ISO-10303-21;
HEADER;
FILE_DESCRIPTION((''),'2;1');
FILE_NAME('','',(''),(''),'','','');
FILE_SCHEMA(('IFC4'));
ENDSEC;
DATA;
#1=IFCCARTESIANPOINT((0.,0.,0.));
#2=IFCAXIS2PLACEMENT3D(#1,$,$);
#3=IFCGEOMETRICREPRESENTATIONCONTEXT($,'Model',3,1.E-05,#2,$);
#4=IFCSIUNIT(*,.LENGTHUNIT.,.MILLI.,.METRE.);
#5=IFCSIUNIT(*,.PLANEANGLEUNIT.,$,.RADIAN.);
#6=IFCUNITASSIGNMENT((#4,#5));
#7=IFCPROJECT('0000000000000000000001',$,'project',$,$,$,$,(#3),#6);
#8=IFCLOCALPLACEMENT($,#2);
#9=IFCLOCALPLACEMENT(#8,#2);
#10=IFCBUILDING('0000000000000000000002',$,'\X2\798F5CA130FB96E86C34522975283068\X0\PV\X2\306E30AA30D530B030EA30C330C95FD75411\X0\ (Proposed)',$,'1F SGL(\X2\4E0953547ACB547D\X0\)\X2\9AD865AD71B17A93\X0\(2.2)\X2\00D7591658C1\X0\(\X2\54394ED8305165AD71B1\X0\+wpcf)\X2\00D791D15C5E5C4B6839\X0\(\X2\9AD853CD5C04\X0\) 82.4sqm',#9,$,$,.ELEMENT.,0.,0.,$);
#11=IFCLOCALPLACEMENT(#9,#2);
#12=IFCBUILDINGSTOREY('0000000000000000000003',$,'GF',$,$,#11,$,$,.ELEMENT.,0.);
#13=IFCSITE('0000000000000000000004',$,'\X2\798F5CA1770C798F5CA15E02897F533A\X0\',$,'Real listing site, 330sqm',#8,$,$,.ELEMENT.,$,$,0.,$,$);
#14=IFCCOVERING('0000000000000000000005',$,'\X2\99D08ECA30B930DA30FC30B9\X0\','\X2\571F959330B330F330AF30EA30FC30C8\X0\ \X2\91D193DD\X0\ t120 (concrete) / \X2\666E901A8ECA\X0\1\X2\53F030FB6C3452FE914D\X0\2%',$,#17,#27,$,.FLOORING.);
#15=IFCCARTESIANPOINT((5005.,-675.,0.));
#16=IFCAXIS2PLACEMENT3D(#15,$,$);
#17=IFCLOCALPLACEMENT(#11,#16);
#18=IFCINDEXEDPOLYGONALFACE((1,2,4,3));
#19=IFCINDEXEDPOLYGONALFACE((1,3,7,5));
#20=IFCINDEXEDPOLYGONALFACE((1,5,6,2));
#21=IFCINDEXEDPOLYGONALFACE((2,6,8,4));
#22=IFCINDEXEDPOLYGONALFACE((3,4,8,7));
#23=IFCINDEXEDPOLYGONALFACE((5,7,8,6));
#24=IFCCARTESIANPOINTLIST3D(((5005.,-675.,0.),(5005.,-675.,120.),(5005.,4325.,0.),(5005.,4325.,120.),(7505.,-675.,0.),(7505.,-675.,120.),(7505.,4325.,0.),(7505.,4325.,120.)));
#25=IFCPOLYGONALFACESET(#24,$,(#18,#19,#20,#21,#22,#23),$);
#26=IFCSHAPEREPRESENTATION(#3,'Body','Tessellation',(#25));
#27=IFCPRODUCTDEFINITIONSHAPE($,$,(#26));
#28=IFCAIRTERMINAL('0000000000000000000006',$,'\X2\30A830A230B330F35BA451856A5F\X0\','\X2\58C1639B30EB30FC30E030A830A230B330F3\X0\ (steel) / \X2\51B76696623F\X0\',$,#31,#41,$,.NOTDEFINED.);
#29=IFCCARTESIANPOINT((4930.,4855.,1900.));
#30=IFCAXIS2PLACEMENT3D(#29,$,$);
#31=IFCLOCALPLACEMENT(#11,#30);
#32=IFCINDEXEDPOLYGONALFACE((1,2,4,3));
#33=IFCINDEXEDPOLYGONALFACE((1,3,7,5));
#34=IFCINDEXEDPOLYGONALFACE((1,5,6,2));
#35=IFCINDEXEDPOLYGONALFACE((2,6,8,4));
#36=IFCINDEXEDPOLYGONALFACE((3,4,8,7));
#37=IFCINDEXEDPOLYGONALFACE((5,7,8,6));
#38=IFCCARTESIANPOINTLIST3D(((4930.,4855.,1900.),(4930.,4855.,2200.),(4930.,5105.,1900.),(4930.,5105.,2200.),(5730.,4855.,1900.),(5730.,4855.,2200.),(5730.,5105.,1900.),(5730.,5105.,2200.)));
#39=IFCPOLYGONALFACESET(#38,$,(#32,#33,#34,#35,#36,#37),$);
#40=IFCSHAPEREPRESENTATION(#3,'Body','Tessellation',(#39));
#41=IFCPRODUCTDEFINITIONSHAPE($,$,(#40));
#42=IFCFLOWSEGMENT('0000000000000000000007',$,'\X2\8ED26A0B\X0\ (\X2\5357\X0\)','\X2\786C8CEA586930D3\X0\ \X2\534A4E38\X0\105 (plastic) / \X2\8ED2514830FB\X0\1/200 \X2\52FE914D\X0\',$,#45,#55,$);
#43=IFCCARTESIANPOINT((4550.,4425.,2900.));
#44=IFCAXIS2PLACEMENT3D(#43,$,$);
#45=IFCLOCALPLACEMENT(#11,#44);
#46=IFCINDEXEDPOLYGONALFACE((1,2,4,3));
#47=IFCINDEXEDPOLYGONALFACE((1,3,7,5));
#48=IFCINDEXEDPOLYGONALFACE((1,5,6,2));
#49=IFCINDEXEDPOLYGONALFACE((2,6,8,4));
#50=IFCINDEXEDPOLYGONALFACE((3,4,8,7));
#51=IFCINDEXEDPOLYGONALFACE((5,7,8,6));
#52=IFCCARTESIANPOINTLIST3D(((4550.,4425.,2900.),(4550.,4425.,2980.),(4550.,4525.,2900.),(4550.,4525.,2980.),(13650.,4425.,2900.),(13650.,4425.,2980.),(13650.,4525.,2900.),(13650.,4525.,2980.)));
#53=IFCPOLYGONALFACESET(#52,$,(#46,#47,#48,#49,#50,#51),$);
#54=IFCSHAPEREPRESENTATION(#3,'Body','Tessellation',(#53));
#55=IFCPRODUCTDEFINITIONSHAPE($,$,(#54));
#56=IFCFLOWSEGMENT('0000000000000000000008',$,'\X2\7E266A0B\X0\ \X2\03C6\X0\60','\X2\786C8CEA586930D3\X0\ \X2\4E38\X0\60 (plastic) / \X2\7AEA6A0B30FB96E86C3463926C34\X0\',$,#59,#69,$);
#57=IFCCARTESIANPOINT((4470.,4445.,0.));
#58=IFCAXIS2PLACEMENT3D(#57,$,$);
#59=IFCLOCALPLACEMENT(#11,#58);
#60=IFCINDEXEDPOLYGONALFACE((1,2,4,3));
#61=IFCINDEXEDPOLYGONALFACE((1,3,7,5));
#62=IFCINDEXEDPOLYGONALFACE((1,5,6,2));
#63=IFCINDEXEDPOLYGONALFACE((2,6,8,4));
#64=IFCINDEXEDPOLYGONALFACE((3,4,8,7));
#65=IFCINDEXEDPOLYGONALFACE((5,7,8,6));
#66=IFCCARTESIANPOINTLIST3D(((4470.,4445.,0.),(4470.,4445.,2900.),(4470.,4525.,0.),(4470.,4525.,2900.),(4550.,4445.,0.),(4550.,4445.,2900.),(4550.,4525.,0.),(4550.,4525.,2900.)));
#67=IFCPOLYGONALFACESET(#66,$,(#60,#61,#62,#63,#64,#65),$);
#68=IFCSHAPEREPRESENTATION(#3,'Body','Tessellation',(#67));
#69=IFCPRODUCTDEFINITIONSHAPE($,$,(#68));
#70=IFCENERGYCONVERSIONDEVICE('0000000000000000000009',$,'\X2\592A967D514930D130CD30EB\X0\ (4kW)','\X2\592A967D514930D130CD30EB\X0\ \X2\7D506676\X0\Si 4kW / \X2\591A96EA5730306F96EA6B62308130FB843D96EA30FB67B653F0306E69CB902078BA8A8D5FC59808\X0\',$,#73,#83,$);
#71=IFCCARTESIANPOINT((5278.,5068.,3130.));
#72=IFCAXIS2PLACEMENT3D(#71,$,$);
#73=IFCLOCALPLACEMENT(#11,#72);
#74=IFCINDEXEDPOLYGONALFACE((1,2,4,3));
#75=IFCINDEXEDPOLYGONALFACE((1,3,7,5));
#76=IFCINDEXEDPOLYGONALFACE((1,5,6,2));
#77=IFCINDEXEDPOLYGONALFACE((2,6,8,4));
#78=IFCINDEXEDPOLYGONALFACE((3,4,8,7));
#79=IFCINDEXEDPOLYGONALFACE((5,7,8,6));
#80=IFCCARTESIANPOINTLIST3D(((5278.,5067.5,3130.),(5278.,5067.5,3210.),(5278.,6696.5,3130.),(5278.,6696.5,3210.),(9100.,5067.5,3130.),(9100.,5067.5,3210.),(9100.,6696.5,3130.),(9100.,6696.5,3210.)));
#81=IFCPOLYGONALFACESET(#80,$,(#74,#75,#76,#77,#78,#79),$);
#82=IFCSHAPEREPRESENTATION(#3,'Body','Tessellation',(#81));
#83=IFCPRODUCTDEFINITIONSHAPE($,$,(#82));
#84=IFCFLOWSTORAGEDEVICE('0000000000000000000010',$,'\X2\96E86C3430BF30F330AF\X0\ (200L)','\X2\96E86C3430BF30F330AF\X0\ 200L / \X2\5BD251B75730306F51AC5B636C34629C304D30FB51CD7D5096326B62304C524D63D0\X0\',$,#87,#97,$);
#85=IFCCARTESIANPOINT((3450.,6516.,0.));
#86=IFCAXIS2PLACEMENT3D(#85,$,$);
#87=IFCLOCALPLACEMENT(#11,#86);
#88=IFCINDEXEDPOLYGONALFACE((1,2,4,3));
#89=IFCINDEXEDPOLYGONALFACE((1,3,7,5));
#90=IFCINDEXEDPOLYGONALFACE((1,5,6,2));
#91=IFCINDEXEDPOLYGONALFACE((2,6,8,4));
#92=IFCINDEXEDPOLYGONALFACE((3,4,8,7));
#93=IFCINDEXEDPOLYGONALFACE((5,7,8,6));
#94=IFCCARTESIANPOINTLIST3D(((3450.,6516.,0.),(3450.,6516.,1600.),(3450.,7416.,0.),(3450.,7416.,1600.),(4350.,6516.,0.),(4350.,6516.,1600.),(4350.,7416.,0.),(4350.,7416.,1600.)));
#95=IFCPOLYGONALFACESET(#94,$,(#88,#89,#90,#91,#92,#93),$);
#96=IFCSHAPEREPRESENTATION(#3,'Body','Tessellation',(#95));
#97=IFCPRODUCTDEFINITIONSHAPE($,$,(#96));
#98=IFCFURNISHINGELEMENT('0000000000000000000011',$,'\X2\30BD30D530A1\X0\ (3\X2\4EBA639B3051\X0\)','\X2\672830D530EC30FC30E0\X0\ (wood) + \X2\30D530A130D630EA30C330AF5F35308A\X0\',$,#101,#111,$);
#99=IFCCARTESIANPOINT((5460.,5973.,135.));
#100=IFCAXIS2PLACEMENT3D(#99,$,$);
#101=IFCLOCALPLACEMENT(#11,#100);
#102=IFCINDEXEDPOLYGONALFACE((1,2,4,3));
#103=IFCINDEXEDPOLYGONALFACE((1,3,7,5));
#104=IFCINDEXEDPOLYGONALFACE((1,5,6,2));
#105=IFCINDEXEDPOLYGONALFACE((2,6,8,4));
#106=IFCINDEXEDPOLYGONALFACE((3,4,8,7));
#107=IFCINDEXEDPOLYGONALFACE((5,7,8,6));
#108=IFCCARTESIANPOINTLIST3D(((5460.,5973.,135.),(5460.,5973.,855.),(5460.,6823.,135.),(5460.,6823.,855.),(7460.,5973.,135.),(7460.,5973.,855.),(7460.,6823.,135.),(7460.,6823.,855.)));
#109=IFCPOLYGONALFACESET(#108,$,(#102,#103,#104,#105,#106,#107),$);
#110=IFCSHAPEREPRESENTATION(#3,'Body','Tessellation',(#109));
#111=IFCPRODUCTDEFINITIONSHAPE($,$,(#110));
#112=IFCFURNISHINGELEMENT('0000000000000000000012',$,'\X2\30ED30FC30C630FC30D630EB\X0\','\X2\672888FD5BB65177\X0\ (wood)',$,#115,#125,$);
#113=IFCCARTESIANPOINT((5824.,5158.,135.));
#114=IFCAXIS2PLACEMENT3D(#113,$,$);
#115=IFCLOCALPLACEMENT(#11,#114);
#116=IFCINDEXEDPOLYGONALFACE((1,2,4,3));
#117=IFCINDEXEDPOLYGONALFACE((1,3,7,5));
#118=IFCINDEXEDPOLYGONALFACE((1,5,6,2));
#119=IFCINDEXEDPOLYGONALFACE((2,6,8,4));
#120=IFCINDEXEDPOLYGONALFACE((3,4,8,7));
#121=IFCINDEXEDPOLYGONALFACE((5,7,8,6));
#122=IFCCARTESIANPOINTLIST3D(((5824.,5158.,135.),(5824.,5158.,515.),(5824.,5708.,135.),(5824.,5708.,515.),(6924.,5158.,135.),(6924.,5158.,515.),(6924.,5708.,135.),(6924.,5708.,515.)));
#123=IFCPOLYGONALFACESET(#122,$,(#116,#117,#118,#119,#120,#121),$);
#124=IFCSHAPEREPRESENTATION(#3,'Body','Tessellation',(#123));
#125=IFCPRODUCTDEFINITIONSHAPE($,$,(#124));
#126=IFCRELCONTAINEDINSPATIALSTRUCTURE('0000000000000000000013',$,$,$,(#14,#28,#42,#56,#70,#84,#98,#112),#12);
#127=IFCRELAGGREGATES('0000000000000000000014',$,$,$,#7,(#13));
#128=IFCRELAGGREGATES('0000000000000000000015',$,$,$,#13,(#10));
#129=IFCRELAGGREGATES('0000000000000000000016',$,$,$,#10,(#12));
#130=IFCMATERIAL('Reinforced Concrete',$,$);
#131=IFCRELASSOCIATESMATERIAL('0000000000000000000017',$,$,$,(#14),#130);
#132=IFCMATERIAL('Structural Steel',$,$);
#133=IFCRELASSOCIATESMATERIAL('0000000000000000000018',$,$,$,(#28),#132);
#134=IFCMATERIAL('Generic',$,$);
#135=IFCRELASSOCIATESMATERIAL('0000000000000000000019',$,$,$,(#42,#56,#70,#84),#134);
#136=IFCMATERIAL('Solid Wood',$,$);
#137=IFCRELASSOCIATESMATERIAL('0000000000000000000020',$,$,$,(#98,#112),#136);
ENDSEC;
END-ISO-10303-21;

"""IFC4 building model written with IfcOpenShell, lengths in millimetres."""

from ifc_helpers import new_model, si_unit, frame, frame_2d, origin, place, context, project, spatial, rectangle, extrude, material, element, save


model = new_model("IFC4")

# Units and contexts
model_context = context("Model", 3, precision=1e-05, world=origin())
ifc_project = project(units=[si_unit("LENGTHUNIT", "METRE", prefix="MILLI"), si_unit("PLANEANGLEUNIT", "RADIAN")], contexts=[model_context])

# Site, building, storey
site_placement = place(None, origin())
site = spatial("IfcSite", under=ifc_project, at=site_placement, Name="福岡県福岡市西区", ObjectType="Real listing site, 330sqm", CompositionType="ELEMENT", RefElevation=0.0)
building_placement = place(site_placement, origin())
building = spatial("IfcBuilding", under=site, at=building_placement, Name="福岡・雨水利用とPVのオフグリッド志向 (Proposed)", ObjectType="1F SGL(三協立命)高断熱窓(2.2)×外壁(吹付け断熱+wpcf)×金属屋根(高反射) 82.4sqm", CompositionType="ELEMENT", ElevationOfRefHeight=0.0, ElevationOfTerrain=0.0)
storey_placement = place(building_placement, origin())
storey = spatial("IfcBuildingStorey", under=building, at=storey_placement, Name="GF", CompositionType="ELEMENT", Elevation=0.0)

# Shared definitions
ifc_material_1 = material(Name="Solid Wood")

# Shared definitions
ifc_material_2 = material(Name="Reinforced Concrete")

# Shared definitions
ifc_material_3 = material(Name="Structural Steel")

# Covering
ifc_material_4 = material(Name="Generic")
covering_1_placement = place(storey_placement, frame((5005.0, -675.0, 0.0)))
element("IfcCovering", 1, at=covering_1_placement, inside=storey, material=ifc_material_2, Name="駐車スペース", Description="土間コンクリート 金鏝 t120 (concrete) / 普通車1台・水勾配2%", PredefinedType="FLOORING", context=model_context, shape_type="SweptSolid", body=[
    extrude(rectangle(XDim=2500.0, YDim=5000.0, at=frame_2d((1250.0, 2500.0))), frame((5005.0, -675.0, 0.0)), (0.0, 0.0, 1.0), 120.0),
])

# Air terminal
air_terminal_placement = place(storey_placement, frame((4930.0, 4855.0, 1900.0)))
element("IfcAirTerminal", 2, at=air_terminal_placement, inside=storey, material=ifc_material_3, Name="エアコン室内機", Description="壁掛ルームエアコン (steel) / 冷暖房", PredefinedType="NOTDEFINED", context=model_context, shape_type="SweptSolid", body=[
    extrude(rectangle(XDim=800.0, YDim=250.0, at=frame_2d((400.0, 125.0))), frame((4930.0, 4855.0, 1900.0)), (0.0, 0.0, 1.0), 300.0),
])

# Flow segments
flow_segment_1_placement = place(storey_placement, frame((4550.0, 4425.0, 2900.0)))
element("IfcFlowSegment", 3, at=flow_segment_1_placement, inside=storey, material=ifc_material_4, Name="軒樋 (南)", Description="硬質塩ビ 半丸105 (plastic) / 軒先・1/200 勾配", context=model_context, shape_type="SweptSolid", body=[
    extrude(rectangle(XDim=9100.0, YDim=100.0, at=frame_2d((4550.0, 50.0))), frame((4550.0, 4425.0, 2900.0)), (0.0, 0.0, 1.0), 80.0),
])
flow_segment_2_placement = place(storey_placement, frame((4470.0, 4445.0, 0.0)))
element("IfcFlowSegment", 4, at=flow_segment_2_placement, inside=storey, material=ifc_material_4, Name="縦樋 φ60", Description="硬質塩ビ 丸60 (plastic) / 竪樋・雨水排水", context=model_context, shape_type="SweptSolid", body=[
    extrude(rectangle(XDim=80.0, YDim=80.0, at=frame_2d((40.0, 40.0))), frame((4470.0, 4445.0, 0.0)), (0.0, 0.0, 1.0), 2900.0),
])

# Energy conversion device
energy_conversion_device_placement = place(storey_placement, frame((5278.0, 5068.0, 3130.0)))
element("IfcEnergyConversionDevice", 5, at=energy_conversion_device_placement, inside=storey, material=ifc_material_4, Name="太陽光パネル (4kW)", Description="太陽光パネル 結晶Si 4kW / 多雪地は雪止め・落雪・架台の構造確認必須", context=model_context, shape_type="SweptSolid", body=[
    extrude(rectangle(XDim=3822.0, YDim=1629.0, at=frame_2d((1911.0, 814.0))), frame((5278.0, 5068.0, 3130.0)), (0.0, 0.0, 1.0), 80.0),
])

# Flow storage device
flow_storage_device_placement = place(storey_placement, frame((3450.0, 6516.0, 0.0)))
element("IfcFlowStorageDevice", 6, at=flow_storage_device_placement, inside=storey, material=ifc_material_4, Name="雨水タンク (200L)", Description="雨水タンク 200L / 寒冷地は冬季水抜き・凍結防止が前提", context=model_context, shape_type="SweptSolid", body=[
    extrude(rectangle(XDim=900.0, YDim=900.0, at=frame_2d((450.0, 450.0))), frame((3450.0, 6516.0, 0.0)), (0.0, 0.0, 1.0), 1600.0),
])

# Furnishing elements
furnishing_1_placement = place(storey_placement, frame((5460.0, 5973.0, 135.0)))
element("IfcFurnishingElement", 7, at=furnishing_1_placement, inside=storey, material=ifc_material_1, Name="ソファ (3人掛け)", Description="木フレーム (wood) + ファブリック張り", context=model_context, shape_type="SweptSolid", body=[
    extrude(rectangle(XDim=2000.0, YDim=850.0, at=frame_2d((1000.0, 425.0))), frame((5460.0, 5973.0, 135.0)), (0.0, 0.0, 1.0), 720.0),
])
furnishing_2_placement = place(storey_placement, frame((5824.0, 5158.0, 135.0)))
element("IfcFurnishingElement", 8, at=furnishing_2_placement, inside=storey, material=ifc_material_1, Name="ローテーブル", Description="木製家具 (wood)", context=model_context, shape_type="SweptSolid", body=[
    extrude(rectangle(XDim=1100.0, YDim=550.0, at=frame_2d((550.0, 275.0))), frame((5824.0, 5158.0, 135.0)), (0.0, 0.0, 1.0), 380.0),
])

save(model, "model.ifc")
